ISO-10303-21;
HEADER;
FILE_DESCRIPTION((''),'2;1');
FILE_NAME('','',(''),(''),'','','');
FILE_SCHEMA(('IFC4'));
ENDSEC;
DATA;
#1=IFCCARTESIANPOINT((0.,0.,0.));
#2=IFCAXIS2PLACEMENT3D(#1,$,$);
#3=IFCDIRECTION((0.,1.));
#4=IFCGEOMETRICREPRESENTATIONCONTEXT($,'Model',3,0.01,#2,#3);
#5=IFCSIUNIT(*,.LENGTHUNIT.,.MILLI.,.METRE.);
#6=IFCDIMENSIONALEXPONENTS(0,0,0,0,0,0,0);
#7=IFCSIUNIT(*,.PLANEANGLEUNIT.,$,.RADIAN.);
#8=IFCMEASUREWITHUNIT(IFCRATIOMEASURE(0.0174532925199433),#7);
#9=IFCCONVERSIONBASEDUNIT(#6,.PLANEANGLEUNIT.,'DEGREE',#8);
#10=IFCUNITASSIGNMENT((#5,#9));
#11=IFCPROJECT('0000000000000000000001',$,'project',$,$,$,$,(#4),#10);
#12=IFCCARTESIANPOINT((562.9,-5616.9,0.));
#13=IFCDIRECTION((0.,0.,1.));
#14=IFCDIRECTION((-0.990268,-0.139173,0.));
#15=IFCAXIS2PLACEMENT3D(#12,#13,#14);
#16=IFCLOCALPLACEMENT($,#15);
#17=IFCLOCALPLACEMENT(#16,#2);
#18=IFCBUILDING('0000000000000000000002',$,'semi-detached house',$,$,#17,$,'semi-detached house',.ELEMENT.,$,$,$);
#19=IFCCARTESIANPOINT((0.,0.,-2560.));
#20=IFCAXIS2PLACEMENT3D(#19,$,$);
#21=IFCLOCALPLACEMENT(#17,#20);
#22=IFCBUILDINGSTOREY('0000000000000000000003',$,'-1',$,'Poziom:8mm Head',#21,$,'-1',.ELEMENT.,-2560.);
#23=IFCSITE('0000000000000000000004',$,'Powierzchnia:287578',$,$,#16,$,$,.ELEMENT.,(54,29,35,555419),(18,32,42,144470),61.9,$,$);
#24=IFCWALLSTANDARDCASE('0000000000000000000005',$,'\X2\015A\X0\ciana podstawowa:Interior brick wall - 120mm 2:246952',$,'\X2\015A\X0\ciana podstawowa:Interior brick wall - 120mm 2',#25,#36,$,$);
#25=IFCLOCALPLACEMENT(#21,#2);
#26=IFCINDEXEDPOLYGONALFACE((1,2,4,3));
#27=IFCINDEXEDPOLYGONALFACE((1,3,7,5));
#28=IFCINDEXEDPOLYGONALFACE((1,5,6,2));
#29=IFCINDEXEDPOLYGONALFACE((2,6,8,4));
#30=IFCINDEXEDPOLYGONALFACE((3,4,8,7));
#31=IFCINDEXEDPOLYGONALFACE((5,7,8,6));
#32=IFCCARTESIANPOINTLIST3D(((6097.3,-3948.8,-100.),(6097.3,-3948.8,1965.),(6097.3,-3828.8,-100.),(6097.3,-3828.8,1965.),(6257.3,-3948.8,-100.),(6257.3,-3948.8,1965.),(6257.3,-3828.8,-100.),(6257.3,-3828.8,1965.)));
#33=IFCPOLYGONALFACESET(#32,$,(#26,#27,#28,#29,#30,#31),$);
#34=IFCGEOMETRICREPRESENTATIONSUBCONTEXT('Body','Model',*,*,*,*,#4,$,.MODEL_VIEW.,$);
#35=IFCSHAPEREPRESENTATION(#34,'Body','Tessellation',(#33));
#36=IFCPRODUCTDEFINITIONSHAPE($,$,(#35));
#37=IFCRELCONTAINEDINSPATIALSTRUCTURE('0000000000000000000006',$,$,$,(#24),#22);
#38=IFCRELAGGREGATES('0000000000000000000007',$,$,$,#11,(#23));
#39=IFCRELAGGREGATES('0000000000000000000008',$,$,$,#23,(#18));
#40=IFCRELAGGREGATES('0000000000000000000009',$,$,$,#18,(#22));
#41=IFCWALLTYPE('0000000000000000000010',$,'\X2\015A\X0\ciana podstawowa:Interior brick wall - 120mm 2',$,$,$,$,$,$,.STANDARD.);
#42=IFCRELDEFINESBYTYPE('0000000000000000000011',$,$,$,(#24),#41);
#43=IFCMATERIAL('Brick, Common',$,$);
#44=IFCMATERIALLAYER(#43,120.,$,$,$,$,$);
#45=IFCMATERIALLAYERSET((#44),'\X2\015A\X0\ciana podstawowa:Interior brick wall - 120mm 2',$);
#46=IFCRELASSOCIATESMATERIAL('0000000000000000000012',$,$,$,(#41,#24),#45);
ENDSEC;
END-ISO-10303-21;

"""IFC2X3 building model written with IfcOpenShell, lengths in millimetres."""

from ifc_helpers import new_model, entity, si_unit, converted_unit, direction, frame, frame_2d, origin, place, context, subcontext, project, spatial, polyline, rectangle, extrude, clip, bounded_halfspace, material, layer, layer_set, layer_usage, type_object, element, save


model = new_model("IFC2X3")

# Units and contexts
model_context = context("Model", 3, precision=0.01, world=origin(), true_north=direction((0.0, 1.0)))
body_context = subcontext(model_context, "Body", "Model", "MODEL_VIEW")
ifc_project = project(units=[si_unit("LENGTHUNIT", "METRE", prefix="MILLI"), converted_unit("PLANEANGLEUNIT", "DEGREE", entity("IfcRatioMeasure", 0.0174532925199433), si_unit("PLANEANGLEUNIT", "RADIAN"), dimensions=[0, 0, 0, 0, 0, 0, 0])], contexts=[model_context])

# Site, building, storey
site_placement = place(None, frame((562.9, -5616.9, 0.0), z_axis=(0.0, 0.0, 1.0), x_axis=(-0.990268, -0.139173, 0.0)))
site = spatial("IfcSite", under=ifc_project, at=site_placement, Name="Powierzchnia:287578", CompositionType="ELEMENT", RefLatitude=(54, 29, 35, 555419), RefLongitude=(18, 32, 42, 144470), RefElevation=61.9)
building_placement = place(site_placement, origin())
building = spatial("IfcBuilding", under=site, at=building_placement, Name="semi-detached house", LongName="semi-detached house", CompositionType="ELEMENT")
storey_placement = place(building_placement, frame((0.0, 0.0, -2560.0)))
storey = spatial("IfcBuildingStorey", under=building, at=storey_placement, Name="-1", ObjectType="Poziom:8mm Head", LongName="-1", CompositionType="ELEMENT", Elevation=-2560.0)

# Shared definitions
ifc_material_1 = material(Name="Brick, Common")
ifc_layer_1 = layer(ifc_material_1, 120.0)
ifc_layer_set_1 = layer_set([ifc_layer_1], Name="Ściana podstawowa:Interior brick wall - 120mm 2")
wall_type_1 = type_object("IfcWallType", Name="Ściana podstawowa:Interior brick wall - 120mm 2", PredefinedType="STANDARD", material=ifc_layer_set_1)

# Wall
ifc_layer_usage_1 = layer_usage(ifc_layer_set_1, "AXIS2", "NEGATIVE", 60.0)
wall_1_placement = place(storey_placement, frame((6097.3, -3888.8, -100.0)))
element("IfcWallStandardCase", 1, at=wall_1_placement, inside=storey, type_object=wall_type_1, material=ifc_layer_usage_1, Name="Ściana podstawowa:Interior brick wall - 120mm 2:246952", ObjectType="Ściana podstawowa:Interior brick wall - 120mm 2", context=body_context, shape_type="Clipping", body=[
    clip(extrude(rectangle(XDim=160.0, YDim=120.0, at=frame_2d((80.0, 0.0), x_axis=(-1.0, 0.0))), origin(), (0.0, 0.0, 1.0), 2065.0), bounded_halfspace(frame((0.0, -60.0, 2065.0)), False, frame((0.0, -60.0, 2065.0)), polyline([(0.0, 0.0), (160.0, 0.0), (160.0, 120.0), (0.0, 120.0), (0.0, 0.0)]))),
])

save(model, "model.ifc")
